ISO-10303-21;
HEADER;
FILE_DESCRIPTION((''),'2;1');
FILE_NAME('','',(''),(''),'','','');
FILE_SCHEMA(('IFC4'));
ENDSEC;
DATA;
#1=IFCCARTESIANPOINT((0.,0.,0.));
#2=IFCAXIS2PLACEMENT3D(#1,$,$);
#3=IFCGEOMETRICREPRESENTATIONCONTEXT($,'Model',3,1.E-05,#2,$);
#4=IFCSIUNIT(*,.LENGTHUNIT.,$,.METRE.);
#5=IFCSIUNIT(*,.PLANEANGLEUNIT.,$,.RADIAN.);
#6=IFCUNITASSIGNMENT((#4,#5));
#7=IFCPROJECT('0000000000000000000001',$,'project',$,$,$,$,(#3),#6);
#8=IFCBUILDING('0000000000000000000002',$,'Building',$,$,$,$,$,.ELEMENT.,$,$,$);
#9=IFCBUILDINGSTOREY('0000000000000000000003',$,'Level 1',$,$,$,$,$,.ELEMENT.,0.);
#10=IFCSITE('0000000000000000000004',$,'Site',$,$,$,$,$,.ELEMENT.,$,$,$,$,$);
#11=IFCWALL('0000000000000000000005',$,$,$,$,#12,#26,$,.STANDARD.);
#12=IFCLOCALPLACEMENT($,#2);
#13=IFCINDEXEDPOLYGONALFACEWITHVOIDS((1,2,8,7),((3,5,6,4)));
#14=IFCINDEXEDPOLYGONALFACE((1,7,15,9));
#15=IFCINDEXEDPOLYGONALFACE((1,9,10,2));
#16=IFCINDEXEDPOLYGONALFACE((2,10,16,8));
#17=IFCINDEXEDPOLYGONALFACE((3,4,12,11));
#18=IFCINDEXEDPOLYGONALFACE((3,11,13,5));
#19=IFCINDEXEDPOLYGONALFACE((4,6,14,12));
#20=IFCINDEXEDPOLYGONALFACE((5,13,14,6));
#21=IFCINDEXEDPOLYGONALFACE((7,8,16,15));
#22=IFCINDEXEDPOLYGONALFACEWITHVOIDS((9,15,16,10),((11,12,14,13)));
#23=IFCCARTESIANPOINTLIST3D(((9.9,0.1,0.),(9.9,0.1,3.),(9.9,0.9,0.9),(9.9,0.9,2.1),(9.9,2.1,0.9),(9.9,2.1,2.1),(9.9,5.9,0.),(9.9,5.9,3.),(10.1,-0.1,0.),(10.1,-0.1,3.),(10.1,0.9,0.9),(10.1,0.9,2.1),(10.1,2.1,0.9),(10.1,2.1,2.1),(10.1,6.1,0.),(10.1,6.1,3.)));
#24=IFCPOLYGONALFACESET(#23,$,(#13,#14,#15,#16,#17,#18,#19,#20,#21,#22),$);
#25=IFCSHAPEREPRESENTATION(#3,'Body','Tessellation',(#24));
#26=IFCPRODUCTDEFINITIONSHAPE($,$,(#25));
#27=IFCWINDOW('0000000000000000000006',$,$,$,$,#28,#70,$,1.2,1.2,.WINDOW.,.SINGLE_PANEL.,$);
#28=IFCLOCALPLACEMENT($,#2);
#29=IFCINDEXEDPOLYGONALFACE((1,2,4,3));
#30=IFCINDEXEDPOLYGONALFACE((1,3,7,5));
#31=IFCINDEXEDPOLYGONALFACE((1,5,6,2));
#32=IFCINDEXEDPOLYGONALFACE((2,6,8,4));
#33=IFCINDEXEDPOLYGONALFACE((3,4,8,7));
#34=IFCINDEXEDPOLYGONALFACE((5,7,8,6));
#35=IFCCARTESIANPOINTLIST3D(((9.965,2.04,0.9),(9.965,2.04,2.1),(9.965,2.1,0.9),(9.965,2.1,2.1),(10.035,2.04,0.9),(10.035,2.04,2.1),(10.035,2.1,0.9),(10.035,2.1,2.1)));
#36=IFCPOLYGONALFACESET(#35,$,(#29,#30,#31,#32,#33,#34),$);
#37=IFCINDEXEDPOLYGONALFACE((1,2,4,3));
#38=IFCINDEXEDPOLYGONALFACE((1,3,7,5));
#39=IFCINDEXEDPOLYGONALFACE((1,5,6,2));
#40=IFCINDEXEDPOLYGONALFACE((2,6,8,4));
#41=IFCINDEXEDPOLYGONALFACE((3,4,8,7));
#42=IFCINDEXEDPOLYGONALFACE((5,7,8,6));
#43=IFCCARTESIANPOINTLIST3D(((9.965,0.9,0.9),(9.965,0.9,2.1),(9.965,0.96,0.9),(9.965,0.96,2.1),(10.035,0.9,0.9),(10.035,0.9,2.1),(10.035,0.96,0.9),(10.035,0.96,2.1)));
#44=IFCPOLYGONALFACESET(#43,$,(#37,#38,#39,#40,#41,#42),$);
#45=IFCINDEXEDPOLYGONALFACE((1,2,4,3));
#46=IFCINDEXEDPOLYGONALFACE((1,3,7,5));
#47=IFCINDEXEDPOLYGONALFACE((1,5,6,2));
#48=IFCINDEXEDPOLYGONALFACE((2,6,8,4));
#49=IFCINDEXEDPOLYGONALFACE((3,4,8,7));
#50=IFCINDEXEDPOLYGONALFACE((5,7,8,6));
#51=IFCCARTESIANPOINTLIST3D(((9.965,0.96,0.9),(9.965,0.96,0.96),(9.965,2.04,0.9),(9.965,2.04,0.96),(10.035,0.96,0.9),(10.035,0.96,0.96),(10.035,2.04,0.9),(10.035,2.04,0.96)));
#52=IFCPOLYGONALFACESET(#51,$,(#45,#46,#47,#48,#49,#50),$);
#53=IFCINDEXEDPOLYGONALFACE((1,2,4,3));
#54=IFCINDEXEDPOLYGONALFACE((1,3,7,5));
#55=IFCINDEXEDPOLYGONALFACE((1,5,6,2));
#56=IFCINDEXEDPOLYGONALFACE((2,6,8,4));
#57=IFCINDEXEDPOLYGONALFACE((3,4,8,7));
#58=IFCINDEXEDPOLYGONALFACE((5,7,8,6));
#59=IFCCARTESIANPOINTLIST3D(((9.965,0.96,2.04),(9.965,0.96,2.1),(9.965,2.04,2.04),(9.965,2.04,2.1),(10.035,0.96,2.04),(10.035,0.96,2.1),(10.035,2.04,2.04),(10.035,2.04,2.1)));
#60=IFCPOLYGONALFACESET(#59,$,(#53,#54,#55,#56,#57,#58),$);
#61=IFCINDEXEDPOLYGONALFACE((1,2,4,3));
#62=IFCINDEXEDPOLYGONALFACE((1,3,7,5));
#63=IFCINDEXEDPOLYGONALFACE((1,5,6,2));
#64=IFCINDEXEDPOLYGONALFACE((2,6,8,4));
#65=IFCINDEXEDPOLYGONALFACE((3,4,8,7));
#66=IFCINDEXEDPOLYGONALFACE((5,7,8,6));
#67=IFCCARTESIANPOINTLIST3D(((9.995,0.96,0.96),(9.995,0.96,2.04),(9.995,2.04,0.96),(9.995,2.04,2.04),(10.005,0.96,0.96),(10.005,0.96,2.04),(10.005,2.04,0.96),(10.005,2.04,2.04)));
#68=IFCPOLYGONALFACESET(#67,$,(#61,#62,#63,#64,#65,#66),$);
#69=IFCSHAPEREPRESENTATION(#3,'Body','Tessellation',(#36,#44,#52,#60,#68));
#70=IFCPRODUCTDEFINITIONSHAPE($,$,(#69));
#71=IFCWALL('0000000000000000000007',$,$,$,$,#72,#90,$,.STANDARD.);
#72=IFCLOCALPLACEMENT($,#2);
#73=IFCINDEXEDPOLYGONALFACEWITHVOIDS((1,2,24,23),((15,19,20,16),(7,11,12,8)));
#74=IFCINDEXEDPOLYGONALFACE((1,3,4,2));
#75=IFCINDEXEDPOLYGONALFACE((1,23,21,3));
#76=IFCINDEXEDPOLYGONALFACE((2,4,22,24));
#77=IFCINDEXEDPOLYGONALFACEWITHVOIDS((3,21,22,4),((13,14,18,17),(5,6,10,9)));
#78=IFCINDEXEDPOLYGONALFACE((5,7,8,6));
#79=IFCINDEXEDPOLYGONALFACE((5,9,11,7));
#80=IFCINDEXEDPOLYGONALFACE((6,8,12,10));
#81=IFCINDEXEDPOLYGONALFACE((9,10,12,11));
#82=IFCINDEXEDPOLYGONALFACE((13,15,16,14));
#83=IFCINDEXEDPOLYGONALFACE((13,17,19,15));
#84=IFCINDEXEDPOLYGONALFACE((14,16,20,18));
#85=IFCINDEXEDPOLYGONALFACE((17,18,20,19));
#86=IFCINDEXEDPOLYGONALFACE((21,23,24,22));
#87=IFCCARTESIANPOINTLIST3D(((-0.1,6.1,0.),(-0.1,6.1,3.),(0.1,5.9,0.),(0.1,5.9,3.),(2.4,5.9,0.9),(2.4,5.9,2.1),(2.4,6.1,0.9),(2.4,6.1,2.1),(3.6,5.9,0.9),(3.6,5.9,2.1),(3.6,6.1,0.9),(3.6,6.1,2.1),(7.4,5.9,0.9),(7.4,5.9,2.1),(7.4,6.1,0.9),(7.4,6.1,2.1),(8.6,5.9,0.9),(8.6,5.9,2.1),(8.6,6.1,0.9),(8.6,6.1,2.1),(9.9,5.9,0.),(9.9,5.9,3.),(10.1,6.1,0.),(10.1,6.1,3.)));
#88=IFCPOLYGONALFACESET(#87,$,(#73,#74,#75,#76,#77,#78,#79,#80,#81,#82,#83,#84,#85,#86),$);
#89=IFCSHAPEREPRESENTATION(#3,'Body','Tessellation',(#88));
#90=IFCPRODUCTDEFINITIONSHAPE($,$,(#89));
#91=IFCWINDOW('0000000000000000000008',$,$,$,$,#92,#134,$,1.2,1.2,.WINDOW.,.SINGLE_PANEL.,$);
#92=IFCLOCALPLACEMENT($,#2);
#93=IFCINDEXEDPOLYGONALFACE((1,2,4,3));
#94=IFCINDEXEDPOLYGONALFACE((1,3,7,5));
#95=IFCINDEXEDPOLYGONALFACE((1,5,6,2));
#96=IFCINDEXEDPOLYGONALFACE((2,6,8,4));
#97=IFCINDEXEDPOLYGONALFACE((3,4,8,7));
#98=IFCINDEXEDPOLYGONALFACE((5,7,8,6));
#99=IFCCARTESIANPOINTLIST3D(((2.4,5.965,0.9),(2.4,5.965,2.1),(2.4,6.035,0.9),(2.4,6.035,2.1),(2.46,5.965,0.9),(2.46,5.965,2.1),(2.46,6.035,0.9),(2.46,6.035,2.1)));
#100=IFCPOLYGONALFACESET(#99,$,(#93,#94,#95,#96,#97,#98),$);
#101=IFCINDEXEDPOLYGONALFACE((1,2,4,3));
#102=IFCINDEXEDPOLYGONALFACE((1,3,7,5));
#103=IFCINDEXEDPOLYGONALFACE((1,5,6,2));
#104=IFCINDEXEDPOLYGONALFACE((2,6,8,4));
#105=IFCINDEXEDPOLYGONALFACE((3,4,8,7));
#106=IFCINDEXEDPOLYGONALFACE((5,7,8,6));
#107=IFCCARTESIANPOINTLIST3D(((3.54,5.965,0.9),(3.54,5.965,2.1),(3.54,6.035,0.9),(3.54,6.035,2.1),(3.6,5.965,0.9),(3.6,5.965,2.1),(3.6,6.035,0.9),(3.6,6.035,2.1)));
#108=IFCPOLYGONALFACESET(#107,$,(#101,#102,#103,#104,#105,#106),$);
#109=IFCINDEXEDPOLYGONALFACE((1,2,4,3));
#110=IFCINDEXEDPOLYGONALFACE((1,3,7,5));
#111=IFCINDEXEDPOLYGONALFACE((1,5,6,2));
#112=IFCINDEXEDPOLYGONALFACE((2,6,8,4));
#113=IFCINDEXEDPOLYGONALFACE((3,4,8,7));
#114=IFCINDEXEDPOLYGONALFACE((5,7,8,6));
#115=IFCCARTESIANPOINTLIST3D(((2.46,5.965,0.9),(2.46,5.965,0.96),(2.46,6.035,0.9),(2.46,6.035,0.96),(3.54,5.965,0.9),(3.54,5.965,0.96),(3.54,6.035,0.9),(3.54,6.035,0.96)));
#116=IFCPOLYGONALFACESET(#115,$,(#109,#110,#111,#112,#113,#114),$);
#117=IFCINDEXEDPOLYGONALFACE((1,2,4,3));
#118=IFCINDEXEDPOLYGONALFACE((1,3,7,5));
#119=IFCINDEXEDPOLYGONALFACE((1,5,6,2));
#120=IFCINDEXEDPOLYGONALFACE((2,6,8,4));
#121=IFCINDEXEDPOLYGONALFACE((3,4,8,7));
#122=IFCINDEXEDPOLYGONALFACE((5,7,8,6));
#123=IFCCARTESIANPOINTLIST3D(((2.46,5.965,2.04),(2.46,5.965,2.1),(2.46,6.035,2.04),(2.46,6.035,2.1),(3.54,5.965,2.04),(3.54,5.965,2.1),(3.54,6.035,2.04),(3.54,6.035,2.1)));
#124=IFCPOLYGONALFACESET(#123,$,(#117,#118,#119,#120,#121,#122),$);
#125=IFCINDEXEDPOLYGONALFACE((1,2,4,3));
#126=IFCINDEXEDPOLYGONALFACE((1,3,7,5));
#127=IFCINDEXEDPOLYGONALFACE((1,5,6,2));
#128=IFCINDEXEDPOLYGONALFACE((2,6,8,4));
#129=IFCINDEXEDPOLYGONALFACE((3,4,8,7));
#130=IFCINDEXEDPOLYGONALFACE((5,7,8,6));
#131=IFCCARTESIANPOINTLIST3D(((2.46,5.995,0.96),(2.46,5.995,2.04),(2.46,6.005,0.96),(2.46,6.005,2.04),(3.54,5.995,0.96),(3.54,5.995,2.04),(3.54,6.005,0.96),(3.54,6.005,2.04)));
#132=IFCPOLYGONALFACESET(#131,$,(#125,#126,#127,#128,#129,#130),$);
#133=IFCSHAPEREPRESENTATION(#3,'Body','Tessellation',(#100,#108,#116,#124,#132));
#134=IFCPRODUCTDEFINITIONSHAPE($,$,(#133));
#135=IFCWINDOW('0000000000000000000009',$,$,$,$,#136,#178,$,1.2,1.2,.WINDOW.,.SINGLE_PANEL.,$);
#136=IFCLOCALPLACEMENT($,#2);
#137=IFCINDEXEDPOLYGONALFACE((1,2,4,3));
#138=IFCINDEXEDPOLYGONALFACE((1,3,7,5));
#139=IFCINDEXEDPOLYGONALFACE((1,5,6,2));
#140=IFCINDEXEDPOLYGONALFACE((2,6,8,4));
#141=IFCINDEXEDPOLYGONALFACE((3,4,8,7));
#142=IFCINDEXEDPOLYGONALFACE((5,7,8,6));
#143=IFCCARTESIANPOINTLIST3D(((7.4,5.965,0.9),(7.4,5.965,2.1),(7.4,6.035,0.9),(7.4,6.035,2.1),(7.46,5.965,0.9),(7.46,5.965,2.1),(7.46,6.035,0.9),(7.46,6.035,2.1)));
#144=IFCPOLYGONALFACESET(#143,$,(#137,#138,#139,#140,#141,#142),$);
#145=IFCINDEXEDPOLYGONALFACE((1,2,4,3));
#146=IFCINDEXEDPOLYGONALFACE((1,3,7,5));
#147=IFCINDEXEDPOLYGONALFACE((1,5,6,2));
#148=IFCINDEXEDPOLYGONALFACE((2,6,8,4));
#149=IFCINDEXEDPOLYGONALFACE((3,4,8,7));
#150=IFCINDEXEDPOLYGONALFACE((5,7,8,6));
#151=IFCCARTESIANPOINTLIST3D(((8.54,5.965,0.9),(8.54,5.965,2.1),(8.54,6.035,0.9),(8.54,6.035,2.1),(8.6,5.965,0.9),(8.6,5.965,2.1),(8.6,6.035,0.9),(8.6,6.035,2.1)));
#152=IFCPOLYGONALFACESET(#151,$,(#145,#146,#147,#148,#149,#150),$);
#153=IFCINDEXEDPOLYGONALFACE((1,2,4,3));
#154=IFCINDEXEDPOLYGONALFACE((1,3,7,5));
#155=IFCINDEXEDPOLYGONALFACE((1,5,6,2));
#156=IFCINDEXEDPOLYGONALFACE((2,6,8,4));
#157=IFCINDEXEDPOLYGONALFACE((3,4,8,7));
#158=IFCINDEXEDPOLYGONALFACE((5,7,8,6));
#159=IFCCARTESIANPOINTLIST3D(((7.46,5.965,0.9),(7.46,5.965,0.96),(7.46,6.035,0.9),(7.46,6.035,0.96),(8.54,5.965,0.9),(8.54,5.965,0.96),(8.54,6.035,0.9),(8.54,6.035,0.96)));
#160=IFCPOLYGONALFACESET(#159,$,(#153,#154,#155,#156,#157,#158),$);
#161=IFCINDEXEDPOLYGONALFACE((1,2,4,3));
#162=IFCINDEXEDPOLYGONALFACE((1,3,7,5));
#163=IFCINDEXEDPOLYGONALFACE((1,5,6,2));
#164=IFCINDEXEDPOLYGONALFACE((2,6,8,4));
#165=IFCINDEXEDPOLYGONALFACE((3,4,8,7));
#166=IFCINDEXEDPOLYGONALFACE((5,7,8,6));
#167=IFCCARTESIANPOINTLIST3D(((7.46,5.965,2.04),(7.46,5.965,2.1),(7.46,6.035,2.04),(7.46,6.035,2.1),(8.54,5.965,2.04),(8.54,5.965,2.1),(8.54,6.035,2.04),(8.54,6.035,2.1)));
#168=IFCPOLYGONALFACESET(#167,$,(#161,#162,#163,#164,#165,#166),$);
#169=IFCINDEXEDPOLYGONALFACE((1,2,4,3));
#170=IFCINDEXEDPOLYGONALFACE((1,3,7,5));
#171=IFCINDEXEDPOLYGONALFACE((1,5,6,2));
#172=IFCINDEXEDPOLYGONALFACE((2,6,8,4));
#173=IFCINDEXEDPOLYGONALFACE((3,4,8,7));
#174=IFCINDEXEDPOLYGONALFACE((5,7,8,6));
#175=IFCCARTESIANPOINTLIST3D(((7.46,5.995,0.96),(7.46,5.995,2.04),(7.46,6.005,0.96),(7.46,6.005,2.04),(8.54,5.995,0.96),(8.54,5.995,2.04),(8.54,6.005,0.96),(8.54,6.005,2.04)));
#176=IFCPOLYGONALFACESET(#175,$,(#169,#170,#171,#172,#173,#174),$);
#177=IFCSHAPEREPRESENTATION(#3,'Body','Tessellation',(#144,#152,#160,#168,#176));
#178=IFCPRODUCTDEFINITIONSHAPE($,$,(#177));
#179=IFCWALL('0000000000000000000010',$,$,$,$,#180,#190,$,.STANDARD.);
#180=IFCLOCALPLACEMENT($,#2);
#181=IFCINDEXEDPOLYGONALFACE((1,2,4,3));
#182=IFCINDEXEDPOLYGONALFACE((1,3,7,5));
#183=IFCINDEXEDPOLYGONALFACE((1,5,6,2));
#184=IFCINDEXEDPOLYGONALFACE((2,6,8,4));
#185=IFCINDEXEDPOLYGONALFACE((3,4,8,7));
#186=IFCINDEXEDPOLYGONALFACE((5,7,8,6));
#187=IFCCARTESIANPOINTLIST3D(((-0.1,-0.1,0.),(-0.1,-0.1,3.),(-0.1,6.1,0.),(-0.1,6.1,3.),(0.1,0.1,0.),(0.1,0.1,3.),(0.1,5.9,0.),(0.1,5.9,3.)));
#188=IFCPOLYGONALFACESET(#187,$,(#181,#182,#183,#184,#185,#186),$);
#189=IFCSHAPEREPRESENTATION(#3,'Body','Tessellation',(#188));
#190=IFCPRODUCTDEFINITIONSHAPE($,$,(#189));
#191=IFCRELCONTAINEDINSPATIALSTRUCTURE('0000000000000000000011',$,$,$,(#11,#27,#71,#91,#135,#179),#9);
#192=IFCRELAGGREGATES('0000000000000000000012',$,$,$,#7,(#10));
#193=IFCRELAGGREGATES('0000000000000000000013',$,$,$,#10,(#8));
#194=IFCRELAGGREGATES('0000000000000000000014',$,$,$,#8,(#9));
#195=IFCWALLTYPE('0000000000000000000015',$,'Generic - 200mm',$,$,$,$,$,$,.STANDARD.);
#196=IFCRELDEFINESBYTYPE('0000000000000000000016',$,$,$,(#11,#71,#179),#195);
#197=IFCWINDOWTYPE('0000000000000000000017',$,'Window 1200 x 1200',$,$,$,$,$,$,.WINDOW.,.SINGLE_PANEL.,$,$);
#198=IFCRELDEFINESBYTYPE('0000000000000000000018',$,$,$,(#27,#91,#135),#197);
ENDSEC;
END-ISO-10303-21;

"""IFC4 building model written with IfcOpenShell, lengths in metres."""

from ifc_helpers import new_model, si_unit, frame, frame_2d, origin, origin_with_axes, origin_2d, place, context, project, spatial, polyline, rectangle, outline, extrude, type_object, element, fill, save


model = new_model("IFC4")

# Units and contexts
model_context = context("Model", 3, precision=1e-05, world=origin())
ifc_project = project(units=[si_unit("LENGTHUNIT", "METRE"), si_unit("PLANEANGLEUNIT", "RADIAN")], contexts=[model_context])

# Site, building, storey
site = spatial("IfcSite", under=ifc_project, Name="Site", CompositionType="ELEMENT")
building = spatial("IfcBuilding", under=site, Name="Building", CompositionType="ELEMENT")
storey = spatial("IfcBuildingStorey", under=building, Name="Level 1", CompositionType="ELEMENT", Elevation=0.0)

# Shared definitions
wall_type = type_object("IfcWallType", Name="Generic - 200mm", PredefinedType="STANDARD")
window_type = type_object("IfcWindowType", Name="Window 1200 x 1200", PartitioningType="SINGLE_PANEL", PredefinedType="WINDOW")

# Wall, opening, window
wall_1_placement = place(None, frame((10.0, 6.0, 0.0), z_axis=(0.0, 0.0, 1.0), x_axis=(0.0, -1.0, 0.0)))
wall_1 = element("IfcWall", 1, at=wall_1_placement, inside=storey, type_object=wall_type, PredefinedType="STANDARD", context=model_context, shape_type="SweptSolid", body=[
    extrude(outline(polyline([(0.1, -0.1), (5.9, -0.1), (6.1, 0.1), (-0.1, 0.1), (0.1, -0.1)])), origin(), (0.0, 0.0, 1.0), 3.0),
])
opening_1_placement = place(wall_1_placement, frame((4.5, 0.0, 0.9), z_axis=(0.0, 0.0, 1.0), x_axis=(1.0, 0.0, 0.0)))
opening_1 = element("IfcOpeningElement", 2, at=opening_1_placement, cuts=wall_1, PredefinedType="OPENING", context=model_context, shape_type="SweptSolid", body=[
    extrude(rectangle(XDim=1.2, YDim=0.202, at=origin_2d()), origin(), (0.0, 0.0, 1.0), 1.2),
])
window_1_placement = place(opening_1_placement, origin_with_axes())
window_1 = element("IfcWindow", 3, at=window_1_placement, inside=storey, type_object=window_type, OverallHeight=1.2, OverallWidth=1.2, PartitioningType="SINGLE_PANEL", PredefinedType="WINDOW", context=model_context, shape_type="SweptSolid", body=[
    extrude(rectangle(XDim=0.06, YDim=0.07, at=frame_2d((-0.57, 0.0))), origin(), (0.0, 0.0, 1.0), 1.2),
    extrude(rectangle(XDim=0.06, YDim=0.07, at=frame_2d((0.57, 0.0))), origin(), (0.0, 0.0, 1.0), 1.2),
    extrude(rectangle(XDim=1.08, YDim=0.07, at=origin_2d()), origin(), (0.0, 0.0, 1.0), 0.06),
    extrude(rectangle(XDim=1.08, YDim=0.07, at=origin_2d()), frame((0.0, 0.0, 1.14)), (0.0, 0.0, 1.0), 0.06),
    extrude(rectangle(XDim=1.08, YDim=0.01, at=origin_2d()), frame((0.0, 0.0, 0.06)), (0.0, 0.0, 1.0), 1.08),
])
fill(opening_1, window_1)

# Wall, openings, windows
wall_2_placement = place(None, frame((0.0, 6.0, 0.0), z_axis=(0.0, 0.0, 1.0), x_axis=(1.0, 0.0, 0.0)))
wall_2 = element("IfcWall", 4, at=wall_2_placement, inside=storey, type_object=wall_type, PredefinedType="STANDARD", context=model_context, shape_type="SweptSolid", body=[
    extrude(outline(polyline([(0.1, -0.1), (9.9, -0.1), (10.1, 0.1), (-0.1, 0.1), (0.1, -0.1)])), origin(), (0.0, 0.0, 1.0), 3.0),
])
opening_2_placement = place(wall_2_placement, frame((3.0, 0.0, 0.9), z_axis=(0.0, 0.0, 1.0), x_axis=(1.0, 0.0, 0.0)))
opening_2 = element("IfcOpeningElement", 5, at=opening_2_placement, cuts=wall_2, PredefinedType="OPENING", context=model_context, shape_type="SweptSolid", body=[
    extrude(rectangle(XDim=1.2, YDim=0.202, at=origin_2d()), origin(), (0.0, 0.0, 1.0), 1.2),
])
opening_3_placement = place(wall_2_placement, frame((8.0, 0.0, 0.9), z_axis=(0.0, 0.0, 1.0), x_axis=(1.0, 0.0, 0.0)))
opening_3 = element("IfcOpeningElement", 6, at=opening_3_placement, cuts=wall_2, PredefinedType="OPENING", context=model_context, shape_type="SweptSolid", body=[
    extrude(rectangle(XDim=1.2, YDim=0.202, at=origin_2d()), origin(), (0.0, 0.0, 1.0), 1.2),
])
window_2_placement = place(opening_2_placement, origin_with_axes())
window_2 = element("IfcWindow", 7, at=window_2_placement, inside=storey, type_object=window_type, OverallHeight=1.2, OverallWidth=1.2, PartitioningType="SINGLE_PANEL", PredefinedType="WINDOW", context=model_context, shape_type="SweptSolid", body=[
    extrude(rectangle(XDim=0.06, YDim=0.07, at=frame_2d((-0.57, 0.0))), origin(), (0.0, 0.0, 1.0), 1.2),
    extrude(rectangle(XDim=0.06, YDim=0.07, at=frame_2d((0.57, 0.0))), origin(), (0.0, 0.0, 1.0), 1.2),
    extrude(rectangle(XDim=1.08, YDim=0.07, at=origin_2d()), origin(), (0.0, 0.0, 1.0), 0.06),
    extrude(rectangle(XDim=1.08, YDim=0.07, at=origin_2d()), frame((0.0, 0.0, 1.14)), (0.0, 0.0, 1.0), 0.06),
    extrude(rectangle(XDim=1.08, YDim=0.01, at=origin_2d()), frame((0.0, 0.0, 0.06)), (0.0, 0.0, 1.0), 1.08),
])
fill(opening_2, window_2)
window_3_placement = place(opening_3_placement, origin_with_axes())
window_3 = element("IfcWindow", 8, at=window_3_placement, inside=storey, type_object=window_type, OverallHeight=1.2, OverallWidth=1.2, PartitioningType="SINGLE_PANEL", PredefinedType="WINDOW", context=model_context, shape_type="SweptSolid", body=[
    extrude(rectangle(XDim=0.06, YDim=0.07, at=frame_2d((-0.57, 0.0))), origin(), (0.0, 0.0, 1.0), 1.2),
    extrude(rectangle(XDim=0.06, YDim=0.07, at=frame_2d((0.57, 0.0))), origin(), (0.0, 0.0, 1.0), 1.2),
    extrude(rectangle(XDim=1.08, YDim=0.07, at=origin_2d()), origin(), (0.0, 0.0, 1.0), 0.06),
    extrude(rectangle(XDim=1.08, YDim=0.07, at=origin_2d()), frame((0.0, 0.0, 1.14)), (0.0, 0.0, 1.0), 0.06),
    extrude(rectangle(XDim=1.08, YDim=0.01, at=origin_2d()), frame((0.0, 0.0, 0.06)), (0.0, 0.0, 1.0), 1.08),
])
fill(opening_3, window_3)

# Wall
wall_3_placement = place(None, frame((0.0, 0.0, 0.0), z_axis=(0.0, 0.0, 1.0), x_axis=(0.0, 1.0, 0.0)))
element("IfcWall", 9, at=wall_3_placement, inside=storey, type_object=wall_type, PredefinedType="STANDARD", context=model_context, shape_type="SweptSolid", body=[
    extrude(outline(polyline([(0.1, -0.1), (5.9, -0.1), (6.1, 0.1), (-0.1, 0.1), (0.1, -0.1)])), origin(), (0.0, 0.0, 1.0), 3.0),
])

save(model, "model.ifc")
